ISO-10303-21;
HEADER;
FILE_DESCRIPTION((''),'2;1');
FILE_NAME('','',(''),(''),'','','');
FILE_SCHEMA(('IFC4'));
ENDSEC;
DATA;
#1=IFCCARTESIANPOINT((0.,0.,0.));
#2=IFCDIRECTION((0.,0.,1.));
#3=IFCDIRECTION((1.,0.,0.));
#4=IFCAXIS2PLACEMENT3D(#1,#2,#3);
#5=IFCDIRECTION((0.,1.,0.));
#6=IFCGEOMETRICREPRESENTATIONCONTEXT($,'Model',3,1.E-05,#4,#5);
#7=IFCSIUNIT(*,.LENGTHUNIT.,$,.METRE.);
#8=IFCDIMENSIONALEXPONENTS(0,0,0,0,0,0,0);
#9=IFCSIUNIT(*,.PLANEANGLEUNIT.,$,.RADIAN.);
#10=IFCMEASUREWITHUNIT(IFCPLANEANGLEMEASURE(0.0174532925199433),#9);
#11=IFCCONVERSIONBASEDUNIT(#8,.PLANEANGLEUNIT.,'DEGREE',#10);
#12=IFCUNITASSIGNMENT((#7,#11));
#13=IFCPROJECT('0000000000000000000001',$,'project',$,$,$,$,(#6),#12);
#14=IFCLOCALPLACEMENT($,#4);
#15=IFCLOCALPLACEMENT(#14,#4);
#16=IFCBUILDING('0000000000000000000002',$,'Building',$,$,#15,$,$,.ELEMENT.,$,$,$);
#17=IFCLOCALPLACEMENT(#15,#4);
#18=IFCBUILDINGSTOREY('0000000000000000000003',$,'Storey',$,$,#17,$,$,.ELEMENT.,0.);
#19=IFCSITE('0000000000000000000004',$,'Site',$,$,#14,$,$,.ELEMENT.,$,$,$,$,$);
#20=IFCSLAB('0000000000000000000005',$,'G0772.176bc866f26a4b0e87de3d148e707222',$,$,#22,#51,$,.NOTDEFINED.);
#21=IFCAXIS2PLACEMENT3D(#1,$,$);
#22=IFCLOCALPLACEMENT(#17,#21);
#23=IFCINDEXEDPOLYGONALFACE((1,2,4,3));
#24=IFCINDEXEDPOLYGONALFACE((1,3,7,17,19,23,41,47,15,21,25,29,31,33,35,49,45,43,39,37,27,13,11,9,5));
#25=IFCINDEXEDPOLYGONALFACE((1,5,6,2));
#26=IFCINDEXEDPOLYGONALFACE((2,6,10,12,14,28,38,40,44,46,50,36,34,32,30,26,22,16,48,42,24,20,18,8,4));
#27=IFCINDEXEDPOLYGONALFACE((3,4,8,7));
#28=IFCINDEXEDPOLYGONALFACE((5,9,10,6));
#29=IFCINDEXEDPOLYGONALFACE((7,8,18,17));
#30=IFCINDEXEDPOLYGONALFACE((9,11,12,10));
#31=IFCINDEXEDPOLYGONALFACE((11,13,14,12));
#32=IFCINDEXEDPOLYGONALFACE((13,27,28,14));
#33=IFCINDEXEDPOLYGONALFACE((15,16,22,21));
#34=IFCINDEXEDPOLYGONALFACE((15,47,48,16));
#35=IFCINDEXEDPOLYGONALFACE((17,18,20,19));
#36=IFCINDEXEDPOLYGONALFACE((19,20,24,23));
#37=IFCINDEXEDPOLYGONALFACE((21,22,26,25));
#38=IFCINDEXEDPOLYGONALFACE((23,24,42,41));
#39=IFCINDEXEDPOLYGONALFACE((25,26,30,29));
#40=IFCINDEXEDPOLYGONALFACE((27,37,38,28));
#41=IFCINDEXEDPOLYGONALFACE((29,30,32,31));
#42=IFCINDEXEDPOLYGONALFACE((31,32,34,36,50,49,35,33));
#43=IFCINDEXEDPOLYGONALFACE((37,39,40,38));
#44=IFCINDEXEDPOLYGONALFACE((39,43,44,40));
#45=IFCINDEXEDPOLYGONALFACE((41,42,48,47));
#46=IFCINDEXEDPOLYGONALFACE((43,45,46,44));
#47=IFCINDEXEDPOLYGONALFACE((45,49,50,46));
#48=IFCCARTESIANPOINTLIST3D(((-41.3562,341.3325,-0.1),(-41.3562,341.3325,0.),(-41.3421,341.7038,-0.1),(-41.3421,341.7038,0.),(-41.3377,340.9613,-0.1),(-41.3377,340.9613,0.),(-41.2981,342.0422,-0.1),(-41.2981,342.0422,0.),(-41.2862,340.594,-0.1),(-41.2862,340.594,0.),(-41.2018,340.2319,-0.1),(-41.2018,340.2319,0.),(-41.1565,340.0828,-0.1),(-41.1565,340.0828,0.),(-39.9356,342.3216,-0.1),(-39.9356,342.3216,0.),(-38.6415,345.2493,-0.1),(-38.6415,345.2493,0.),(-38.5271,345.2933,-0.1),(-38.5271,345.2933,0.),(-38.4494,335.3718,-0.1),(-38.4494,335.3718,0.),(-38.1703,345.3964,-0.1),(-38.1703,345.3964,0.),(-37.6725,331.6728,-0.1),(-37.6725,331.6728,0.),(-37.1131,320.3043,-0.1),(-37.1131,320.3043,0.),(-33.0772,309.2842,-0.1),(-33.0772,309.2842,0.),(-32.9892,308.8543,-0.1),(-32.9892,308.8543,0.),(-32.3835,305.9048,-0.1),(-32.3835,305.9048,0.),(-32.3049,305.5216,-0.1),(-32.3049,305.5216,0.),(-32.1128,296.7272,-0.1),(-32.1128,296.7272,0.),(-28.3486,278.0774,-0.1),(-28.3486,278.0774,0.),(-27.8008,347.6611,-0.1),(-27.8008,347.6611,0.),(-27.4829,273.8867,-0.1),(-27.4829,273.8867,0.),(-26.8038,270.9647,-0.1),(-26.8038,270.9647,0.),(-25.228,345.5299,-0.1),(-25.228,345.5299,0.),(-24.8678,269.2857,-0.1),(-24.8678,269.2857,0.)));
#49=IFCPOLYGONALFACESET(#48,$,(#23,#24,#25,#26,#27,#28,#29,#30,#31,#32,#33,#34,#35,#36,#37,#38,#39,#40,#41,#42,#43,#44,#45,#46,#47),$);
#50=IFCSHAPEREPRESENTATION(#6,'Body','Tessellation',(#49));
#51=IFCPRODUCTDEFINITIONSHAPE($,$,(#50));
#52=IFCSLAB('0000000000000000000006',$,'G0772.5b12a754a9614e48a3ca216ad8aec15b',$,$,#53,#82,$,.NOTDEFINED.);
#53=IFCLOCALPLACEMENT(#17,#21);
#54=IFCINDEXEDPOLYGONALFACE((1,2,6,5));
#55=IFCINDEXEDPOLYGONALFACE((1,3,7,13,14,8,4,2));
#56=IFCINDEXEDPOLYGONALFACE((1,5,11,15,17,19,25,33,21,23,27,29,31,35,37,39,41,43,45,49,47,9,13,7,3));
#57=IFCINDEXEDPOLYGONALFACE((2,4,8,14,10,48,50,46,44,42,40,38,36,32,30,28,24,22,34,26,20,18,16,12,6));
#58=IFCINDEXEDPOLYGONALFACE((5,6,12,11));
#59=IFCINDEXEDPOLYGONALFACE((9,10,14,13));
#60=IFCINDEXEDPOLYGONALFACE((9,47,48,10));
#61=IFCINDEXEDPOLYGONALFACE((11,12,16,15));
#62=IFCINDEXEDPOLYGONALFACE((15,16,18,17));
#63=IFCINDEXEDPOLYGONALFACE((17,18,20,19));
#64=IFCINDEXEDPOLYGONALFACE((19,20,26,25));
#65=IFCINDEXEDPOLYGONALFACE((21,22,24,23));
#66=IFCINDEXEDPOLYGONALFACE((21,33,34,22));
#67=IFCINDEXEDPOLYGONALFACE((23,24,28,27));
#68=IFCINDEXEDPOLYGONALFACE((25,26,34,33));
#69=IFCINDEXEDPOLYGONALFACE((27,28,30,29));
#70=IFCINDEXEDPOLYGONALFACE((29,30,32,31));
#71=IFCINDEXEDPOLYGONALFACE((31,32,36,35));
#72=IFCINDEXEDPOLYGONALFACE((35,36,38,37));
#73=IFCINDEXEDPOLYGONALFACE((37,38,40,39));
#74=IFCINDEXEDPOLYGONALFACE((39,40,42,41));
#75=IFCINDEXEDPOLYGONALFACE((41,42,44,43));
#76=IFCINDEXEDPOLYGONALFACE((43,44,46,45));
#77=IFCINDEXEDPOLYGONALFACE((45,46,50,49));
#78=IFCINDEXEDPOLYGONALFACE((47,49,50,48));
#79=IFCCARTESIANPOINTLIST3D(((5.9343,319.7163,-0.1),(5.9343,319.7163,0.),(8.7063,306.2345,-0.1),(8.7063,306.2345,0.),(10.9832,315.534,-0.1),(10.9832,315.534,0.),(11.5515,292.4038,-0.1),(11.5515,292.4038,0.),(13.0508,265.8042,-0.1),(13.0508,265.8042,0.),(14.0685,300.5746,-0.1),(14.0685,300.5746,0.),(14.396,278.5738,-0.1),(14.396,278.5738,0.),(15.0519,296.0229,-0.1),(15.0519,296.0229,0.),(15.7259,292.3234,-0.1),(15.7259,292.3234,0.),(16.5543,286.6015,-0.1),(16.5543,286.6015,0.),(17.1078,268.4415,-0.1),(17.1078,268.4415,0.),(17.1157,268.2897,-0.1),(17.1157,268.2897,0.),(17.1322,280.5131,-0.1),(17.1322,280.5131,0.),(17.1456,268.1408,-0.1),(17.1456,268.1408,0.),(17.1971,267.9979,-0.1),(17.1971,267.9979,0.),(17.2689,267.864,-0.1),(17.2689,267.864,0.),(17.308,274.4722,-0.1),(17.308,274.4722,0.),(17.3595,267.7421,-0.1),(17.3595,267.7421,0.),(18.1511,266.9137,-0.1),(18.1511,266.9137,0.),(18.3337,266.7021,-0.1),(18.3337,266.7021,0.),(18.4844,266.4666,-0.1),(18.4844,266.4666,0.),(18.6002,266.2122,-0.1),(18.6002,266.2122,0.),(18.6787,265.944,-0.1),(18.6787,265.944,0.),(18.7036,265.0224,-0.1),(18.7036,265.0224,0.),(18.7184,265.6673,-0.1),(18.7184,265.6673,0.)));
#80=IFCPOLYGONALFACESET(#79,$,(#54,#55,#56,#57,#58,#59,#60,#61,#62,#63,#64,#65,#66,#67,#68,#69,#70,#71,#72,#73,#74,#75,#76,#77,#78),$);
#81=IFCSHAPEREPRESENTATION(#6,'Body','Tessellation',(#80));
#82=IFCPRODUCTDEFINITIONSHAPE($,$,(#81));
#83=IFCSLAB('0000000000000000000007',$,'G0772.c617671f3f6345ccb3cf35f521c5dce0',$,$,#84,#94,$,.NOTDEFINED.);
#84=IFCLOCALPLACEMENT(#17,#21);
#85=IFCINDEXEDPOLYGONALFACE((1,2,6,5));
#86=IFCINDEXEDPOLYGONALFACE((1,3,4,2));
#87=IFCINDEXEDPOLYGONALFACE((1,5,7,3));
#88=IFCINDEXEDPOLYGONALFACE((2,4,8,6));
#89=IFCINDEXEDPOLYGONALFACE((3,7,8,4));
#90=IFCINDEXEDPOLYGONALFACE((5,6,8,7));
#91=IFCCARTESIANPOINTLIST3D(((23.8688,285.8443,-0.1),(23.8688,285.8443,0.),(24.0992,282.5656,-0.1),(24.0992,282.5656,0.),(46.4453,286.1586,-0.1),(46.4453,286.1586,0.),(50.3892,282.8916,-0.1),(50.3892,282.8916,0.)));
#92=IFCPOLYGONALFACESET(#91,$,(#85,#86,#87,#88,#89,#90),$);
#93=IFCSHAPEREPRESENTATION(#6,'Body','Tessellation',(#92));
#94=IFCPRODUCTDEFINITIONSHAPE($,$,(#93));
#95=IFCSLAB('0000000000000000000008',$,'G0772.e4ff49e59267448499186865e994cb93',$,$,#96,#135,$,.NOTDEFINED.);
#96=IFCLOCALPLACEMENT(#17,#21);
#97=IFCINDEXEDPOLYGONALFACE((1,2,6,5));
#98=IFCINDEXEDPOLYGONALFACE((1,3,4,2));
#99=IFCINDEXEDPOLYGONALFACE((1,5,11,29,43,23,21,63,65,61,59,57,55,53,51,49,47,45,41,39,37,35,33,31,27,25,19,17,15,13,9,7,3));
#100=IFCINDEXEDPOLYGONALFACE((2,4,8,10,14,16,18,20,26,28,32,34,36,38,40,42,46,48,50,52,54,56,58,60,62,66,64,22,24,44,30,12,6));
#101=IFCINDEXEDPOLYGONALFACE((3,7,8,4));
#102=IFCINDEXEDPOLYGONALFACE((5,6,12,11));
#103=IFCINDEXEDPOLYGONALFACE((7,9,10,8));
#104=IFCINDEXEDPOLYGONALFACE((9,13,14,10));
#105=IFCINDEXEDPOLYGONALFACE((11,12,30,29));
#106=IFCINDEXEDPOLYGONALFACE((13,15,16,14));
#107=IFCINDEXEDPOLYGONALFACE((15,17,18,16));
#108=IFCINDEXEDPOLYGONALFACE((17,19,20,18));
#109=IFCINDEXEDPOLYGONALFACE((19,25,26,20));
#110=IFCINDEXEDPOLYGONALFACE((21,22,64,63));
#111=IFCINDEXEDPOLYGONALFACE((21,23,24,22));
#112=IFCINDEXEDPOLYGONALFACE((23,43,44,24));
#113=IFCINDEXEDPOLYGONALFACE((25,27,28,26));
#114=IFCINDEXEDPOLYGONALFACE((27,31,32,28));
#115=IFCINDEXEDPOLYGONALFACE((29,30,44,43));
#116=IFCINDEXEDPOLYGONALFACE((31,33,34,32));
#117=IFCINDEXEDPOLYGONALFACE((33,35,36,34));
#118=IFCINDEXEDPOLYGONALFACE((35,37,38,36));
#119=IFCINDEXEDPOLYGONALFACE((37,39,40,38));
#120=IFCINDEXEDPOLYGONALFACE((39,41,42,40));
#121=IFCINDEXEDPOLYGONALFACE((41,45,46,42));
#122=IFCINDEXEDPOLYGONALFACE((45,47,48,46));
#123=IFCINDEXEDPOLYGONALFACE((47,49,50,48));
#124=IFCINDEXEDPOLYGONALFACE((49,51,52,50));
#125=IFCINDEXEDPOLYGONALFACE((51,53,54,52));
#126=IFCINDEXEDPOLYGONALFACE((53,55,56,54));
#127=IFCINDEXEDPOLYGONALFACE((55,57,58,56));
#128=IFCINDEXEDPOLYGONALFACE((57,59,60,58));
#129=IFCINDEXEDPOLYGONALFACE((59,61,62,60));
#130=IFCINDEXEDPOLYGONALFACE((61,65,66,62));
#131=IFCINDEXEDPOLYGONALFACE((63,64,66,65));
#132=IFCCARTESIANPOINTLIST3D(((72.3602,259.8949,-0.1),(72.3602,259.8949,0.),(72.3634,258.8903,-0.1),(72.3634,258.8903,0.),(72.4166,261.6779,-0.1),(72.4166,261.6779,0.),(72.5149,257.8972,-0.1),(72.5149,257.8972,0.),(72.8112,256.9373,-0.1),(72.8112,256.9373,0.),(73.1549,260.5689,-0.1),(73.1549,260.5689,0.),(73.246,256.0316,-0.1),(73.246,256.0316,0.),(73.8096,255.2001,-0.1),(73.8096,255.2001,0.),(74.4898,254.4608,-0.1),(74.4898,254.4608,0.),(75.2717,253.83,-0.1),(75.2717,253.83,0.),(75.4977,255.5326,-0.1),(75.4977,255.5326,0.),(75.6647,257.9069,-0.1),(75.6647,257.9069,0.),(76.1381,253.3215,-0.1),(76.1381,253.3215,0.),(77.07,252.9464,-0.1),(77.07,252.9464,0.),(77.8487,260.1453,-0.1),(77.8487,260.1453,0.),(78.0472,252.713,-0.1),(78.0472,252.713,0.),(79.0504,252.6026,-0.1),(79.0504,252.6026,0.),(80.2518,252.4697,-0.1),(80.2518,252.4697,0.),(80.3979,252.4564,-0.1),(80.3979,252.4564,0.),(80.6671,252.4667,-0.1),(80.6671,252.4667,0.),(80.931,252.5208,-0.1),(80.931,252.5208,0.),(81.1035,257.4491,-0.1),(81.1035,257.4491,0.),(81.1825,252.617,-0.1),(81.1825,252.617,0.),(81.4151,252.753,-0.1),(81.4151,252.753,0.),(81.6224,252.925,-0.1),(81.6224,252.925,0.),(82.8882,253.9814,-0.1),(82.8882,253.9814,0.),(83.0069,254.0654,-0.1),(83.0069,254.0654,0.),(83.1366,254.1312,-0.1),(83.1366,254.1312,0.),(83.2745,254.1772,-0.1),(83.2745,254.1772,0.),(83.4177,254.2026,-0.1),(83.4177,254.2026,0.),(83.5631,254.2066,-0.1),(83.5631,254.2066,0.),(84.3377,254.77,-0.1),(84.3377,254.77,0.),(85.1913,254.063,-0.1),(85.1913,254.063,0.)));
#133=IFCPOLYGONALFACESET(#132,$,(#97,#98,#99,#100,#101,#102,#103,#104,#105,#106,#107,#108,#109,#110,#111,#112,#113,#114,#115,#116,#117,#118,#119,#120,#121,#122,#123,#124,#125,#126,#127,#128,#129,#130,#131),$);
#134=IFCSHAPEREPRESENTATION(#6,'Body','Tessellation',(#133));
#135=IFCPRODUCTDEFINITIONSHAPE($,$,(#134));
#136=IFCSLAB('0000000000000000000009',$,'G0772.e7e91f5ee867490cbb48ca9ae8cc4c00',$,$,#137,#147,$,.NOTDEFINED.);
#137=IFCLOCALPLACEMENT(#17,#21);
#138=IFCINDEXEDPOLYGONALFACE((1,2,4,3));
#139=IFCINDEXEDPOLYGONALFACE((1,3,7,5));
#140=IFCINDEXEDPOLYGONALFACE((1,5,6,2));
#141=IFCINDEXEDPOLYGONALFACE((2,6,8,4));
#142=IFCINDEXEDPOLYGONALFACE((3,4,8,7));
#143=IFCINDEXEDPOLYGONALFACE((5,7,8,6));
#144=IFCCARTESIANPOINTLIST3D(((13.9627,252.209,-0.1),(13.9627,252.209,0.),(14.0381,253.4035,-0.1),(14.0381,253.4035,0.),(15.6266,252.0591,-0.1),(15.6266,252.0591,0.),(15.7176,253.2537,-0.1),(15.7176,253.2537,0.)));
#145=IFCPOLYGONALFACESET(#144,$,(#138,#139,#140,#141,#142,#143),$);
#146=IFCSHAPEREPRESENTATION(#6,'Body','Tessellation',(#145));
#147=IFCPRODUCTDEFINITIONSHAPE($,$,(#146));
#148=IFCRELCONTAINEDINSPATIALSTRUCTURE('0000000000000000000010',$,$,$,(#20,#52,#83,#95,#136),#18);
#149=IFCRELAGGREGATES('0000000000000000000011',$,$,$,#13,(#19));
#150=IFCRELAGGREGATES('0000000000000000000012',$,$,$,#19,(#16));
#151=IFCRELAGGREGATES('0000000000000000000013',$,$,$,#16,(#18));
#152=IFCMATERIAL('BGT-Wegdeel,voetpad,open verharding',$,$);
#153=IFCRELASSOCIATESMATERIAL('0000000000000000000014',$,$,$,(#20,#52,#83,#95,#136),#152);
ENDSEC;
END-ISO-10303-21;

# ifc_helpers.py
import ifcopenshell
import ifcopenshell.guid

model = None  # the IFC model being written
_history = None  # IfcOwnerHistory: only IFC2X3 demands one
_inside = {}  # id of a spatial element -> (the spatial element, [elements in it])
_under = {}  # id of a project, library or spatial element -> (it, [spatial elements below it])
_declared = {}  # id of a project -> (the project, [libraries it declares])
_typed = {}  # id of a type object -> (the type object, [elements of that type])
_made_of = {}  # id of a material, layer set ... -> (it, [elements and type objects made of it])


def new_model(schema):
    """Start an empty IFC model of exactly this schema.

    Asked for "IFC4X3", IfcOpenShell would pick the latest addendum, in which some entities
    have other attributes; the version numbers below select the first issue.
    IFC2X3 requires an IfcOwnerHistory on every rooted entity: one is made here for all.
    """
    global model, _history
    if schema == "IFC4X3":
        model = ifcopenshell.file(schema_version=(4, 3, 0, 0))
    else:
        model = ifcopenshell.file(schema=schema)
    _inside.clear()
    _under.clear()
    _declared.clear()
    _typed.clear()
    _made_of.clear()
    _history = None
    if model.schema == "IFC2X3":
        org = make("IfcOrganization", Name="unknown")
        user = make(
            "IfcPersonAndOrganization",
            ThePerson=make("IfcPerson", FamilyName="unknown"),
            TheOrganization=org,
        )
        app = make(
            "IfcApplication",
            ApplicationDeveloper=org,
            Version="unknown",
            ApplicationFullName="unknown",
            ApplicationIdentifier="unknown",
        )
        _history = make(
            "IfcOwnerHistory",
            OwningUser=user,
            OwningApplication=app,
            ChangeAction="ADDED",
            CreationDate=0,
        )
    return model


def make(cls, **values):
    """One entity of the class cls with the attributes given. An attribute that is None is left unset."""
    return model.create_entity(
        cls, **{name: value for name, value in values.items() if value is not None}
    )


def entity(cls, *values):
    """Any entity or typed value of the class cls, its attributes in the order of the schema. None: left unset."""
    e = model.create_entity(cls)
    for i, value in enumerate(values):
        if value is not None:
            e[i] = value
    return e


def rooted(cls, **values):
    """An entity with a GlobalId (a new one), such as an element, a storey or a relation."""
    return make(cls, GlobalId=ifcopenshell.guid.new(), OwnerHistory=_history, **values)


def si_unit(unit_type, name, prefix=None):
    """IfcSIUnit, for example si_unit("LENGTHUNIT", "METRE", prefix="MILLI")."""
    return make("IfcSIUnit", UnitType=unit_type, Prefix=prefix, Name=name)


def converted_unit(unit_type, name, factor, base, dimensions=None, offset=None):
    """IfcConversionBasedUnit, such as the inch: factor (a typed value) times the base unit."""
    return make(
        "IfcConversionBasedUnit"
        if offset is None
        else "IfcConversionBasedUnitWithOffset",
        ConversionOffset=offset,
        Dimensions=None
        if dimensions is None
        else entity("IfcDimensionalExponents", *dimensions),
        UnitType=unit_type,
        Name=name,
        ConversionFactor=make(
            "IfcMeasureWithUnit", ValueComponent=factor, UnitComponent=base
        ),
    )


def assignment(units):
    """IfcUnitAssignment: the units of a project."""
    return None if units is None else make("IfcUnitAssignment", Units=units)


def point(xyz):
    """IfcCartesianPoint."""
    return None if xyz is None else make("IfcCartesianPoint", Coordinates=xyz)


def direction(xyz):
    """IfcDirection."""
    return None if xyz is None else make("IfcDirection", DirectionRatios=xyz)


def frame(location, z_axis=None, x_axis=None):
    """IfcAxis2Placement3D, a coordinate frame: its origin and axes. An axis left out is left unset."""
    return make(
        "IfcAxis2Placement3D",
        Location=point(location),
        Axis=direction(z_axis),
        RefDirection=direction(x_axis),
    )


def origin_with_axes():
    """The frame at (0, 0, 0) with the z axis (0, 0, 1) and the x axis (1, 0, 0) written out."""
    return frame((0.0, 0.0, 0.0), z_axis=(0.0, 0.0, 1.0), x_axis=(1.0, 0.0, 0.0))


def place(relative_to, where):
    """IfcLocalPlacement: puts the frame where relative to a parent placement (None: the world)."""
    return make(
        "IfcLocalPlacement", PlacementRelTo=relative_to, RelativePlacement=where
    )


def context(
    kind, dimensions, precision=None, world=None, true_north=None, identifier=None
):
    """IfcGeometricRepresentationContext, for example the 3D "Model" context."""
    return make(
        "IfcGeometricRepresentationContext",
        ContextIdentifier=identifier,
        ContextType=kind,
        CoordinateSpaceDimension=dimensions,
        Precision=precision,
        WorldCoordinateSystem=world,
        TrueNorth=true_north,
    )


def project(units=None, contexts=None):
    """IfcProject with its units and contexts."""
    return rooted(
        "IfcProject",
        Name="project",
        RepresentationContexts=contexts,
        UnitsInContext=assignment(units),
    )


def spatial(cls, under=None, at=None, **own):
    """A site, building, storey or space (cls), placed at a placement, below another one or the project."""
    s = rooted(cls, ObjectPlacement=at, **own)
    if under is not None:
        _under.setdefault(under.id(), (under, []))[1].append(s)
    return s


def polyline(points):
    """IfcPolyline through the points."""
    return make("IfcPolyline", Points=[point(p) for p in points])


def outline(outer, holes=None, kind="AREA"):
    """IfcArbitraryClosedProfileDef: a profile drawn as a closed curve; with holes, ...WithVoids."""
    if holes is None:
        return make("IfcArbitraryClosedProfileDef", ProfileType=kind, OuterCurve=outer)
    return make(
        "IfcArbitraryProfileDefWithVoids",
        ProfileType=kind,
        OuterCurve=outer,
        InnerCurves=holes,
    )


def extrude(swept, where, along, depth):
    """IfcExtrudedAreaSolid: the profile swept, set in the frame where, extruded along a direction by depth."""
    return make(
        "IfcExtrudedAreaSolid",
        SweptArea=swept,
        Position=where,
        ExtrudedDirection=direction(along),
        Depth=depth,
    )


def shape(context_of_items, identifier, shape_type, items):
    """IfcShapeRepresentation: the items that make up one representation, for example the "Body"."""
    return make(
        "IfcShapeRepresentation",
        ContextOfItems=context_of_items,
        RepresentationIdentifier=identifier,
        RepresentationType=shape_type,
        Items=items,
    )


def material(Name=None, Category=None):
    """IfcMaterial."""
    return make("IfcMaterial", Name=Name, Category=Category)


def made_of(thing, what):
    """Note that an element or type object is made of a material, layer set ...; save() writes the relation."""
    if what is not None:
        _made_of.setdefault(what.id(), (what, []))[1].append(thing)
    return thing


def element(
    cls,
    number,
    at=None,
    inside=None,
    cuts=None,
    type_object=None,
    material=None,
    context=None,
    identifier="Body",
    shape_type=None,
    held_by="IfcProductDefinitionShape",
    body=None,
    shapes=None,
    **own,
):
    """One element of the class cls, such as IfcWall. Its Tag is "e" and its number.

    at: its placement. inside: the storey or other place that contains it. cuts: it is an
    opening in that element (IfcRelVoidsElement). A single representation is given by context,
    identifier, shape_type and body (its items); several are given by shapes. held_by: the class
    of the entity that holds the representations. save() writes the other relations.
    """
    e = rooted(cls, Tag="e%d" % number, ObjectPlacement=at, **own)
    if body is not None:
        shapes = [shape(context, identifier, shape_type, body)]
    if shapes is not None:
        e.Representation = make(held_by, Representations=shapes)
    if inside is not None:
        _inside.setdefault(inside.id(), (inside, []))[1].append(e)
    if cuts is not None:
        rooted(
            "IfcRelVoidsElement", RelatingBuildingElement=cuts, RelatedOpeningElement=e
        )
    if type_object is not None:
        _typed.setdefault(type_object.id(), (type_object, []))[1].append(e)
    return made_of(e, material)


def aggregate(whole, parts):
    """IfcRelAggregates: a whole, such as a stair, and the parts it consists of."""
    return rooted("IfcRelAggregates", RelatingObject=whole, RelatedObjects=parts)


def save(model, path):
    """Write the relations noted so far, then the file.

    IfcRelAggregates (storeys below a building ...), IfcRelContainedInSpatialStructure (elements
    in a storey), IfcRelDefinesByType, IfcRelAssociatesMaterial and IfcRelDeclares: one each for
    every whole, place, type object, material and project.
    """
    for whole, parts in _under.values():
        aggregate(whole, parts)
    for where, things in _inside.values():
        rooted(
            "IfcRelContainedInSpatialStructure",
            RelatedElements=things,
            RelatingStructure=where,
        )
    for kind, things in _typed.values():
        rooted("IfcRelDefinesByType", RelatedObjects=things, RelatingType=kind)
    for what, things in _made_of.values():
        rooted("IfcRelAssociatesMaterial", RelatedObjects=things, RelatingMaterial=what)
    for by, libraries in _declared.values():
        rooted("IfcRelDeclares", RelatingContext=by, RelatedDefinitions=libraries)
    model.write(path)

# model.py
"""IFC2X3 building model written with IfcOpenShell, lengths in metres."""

from ifc_helpers import new_model, entity, si_unit, converted_unit, direction, frame, origin_with_axes, place, context, project, spatial, polyline, outline, extrude, material, element, save


model = new_model("IFC2X3")

# Units and contexts
model_context = context("Model", 3, precision=1e-05, world=origin_with_axes(), true_north=direction((0.0, 1.0, 0.0)))
ifc_project = project(units=[si_unit("LENGTHUNIT", "METRE"), converted_unit("PLANEANGLEUNIT", "DEGREE", entity("IfcPlaneAngleMeasure", 0.0174532925199433), si_unit("PLANEANGLEUNIT", "RADIAN"), dimensions=[0, 0, 0, 0, 0, 0, 0])], contexts=[model_context])

# Site, building, storey
site_placement = place(None, origin_with_axes())
site = spatial("IfcSite", under=ifc_project, at=site_placement, Name="Site", CompositionType="ELEMENT")
building_placement = place(site_placement, origin_with_axes())
building = spatial("IfcBuilding", under=site, at=building_placement, Name="Building", CompositionType="ELEMENT")
storey_placement = place(building_placement, origin_with_axes())
storey = spatial("IfcBuildingStorey", under=building, at=storey_placement, Name="Storey", CompositionType="ELEMENT", Elevation=0.0)

# Slabs
ifc_material_1 = material(Name="BGT-Wegdeel,voetpad,open verharding")
slab_1_placement = place(storey_placement, frame((0.0, 0.0, -0.1), z_axis=(0.0, 0.0, 1.0), x_axis=(1.0, 0.0, 0.0)))
element("IfcSlab", 1, at=slab_1_placement, inside=storey, material=ifc_material_1, Name="G0772.176bc866f26a4b0e87de3d148e707222", PredefinedType="NOTDEFINED", context=model_context, shape_type="SweptSolid", body=[
    extrude(outline(polyline([(-38.5271, 345.2933), (-38.1703, 345.3964), (-27.8008, 347.6611), (-25.228, 345.5299), (-39.9356, 342.3216), (-38.4494, 335.3718), (-37.6725, 331.6728), (-33.0772, 309.2842), (-32.9892, 308.8543), (-32.3835, 305.9048), (-32.3049, 305.5216), (-24.8678, 269.2857), (-26.8038, 270.9647), (-27.4829, 273.8867), (-28.3486, 278.0774), (-32.1128, 296.7272), (-37.1131, 320.3043), (-41.1565, 340.0828), (-41.2018, 340.2319), (-41.2862, 340.594), (-41.3377, 340.9613), (-41.3562, 341.3325), (-41.3421, 341.7038), (-41.2981, 342.0422), (-38.6415, 345.2493), (-38.5271, 345.2933)])), origin_with_axes(), (0.0, 0.0, 1.0), 0.1),
])
slab_2_placement = place(storey_placement, frame((0.0, 0.0, -0.1), z_axis=(0.0, 0.0, 1.0), x_axis=(1.0, 0.0, 0.0)))
element("IfcSlab", 2, at=slab_2_placement, inside=storey, material=ifc_material_1, Name="G0772.5b12a754a9614e48a3ca216ad8aec15b", PredefinedType="NOTDEFINED", context=model_context, shape_type="SweptSolid", body=[
    extrude(outline(polyline([(14.0685, 300.5746), (15.0519, 296.0229), (15.7259, 292.3234), (16.5543, 286.6015), (17.1322, 280.5131), (17.308, 274.4722), (17.1078, 268.4415), (17.1157, 268.2897), (17.1456, 268.1408), (17.1971, 267.9979), (17.2689, 267.864), (17.3595, 267.7421), (18.1511, 266.9137), (18.3337, 266.7021), (18.4844, 266.4666), (18.6002, 266.2122), (18.6787, 265.944), (18.7184, 265.6673), (18.7036, 265.0224), (13.0508, 265.8042), (14.396, 278.5738), (11.5515, 292.4038), (8.7063, 306.2345), (5.9343, 319.7163), (10.9832, 315.534), (14.0685, 300.5746)])), origin_with_axes(), (0.0, 0.0, 1.0), 0.1),
])
slab_3_placement = place(storey_placement, frame((0.0, 0.0, -0.1), z_axis=(0.0, 0.0, 1.0), x_axis=(1.0, 0.0, 0.0)))
element("IfcSlab", 3, at=slab_3_placement, inside=storey, material=ifc_material_1, Name="G0772.c617671f3f6345ccb3cf35f521c5dce0", PredefinedType="NOTDEFINED", context=model_context, shape_type="SweptSolid", body=[
    extrude(outline(polyline([(24.0992, 282.5656), (23.8688, 285.8443), (46.4453, 286.1586), (50.3892, 282.8916), (24.0992, 282.5656)])), origin_with_axes(), (0.0, 0.0, 1.0), 0.1),
])
slab_4_placement = place(storey_placement, frame((0.0, 0.0, -0.1), z_axis=(0.0, 0.0, 1.0), x_axis=(1.0, 0.0, 0.0)))
element("IfcSlab", 4, at=slab_4_placement, inside=storey, material=ifc_material_1, Name="G0772.e4ff49e59267448499186865e994cb93", PredefinedType="NOTDEFINED", context=model_context, shape_type="SweptSolid", body=[
    extrude(outline(polyline([(83.5631, 254.2066), (83.4177, 254.2026), (83.2745, 254.1772), (83.1366, 254.1312), (83.0069, 254.0654), (82.8882, 253.9814), (81.6224, 252.925), (81.4151, 252.753), (81.1825, 252.617), (80.931, 252.5208), (80.6671, 252.4667), (80.3979, 252.4564), (80.2518, 252.4697), (79.0504, 252.6026), (78.0472, 252.713), (77.07, 252.9464), (76.1381, 253.3215), (75.2717, 253.83), (74.4898, 254.4608), (73.8096, 255.2001), (73.246, 256.0316), (72.8112, 256.9373), (72.5149, 257.8972), (72.3634, 258.8903), (72.3602, 259.8949), (72.4166, 261.6779), (73.1549, 260.5689), (77.8487, 260.1453), (81.1035, 257.4491), (75.6647, 257.9069), (75.4977, 255.5326), (84.3377, 254.77), (85.1913, 254.063), (83.5631, 254.2066)])), origin_with_axes(), (0.0, 0.0, 1.0), 0.1),
])
slab_5_placement = place(storey_placement, frame((0.0, 0.0, -0.1), z_axis=(0.0, 0.0, 1.0), x_axis=(1.0, 0.0, 0.0)))
element("IfcSlab", 5, at=slab_5_placement, inside=storey, material=ifc_material_1, Name="G0772.e7e91f5ee867490cbb48ca9ae8cc4c00", PredefinedType="NOTDEFINED", context=model_context, shape_type="SweptSolid", body=[
    extrude(outline(polyline([(15.7176, 253.2537), (15.6266, 252.0591), (13.9627, 252.209), (14.0381, 253.4035), (15.7176, 253.2537)])), origin_with_axes(), (0.0, 0.0, 1.0), 0.1),
])

save(model, "model.ifc")
